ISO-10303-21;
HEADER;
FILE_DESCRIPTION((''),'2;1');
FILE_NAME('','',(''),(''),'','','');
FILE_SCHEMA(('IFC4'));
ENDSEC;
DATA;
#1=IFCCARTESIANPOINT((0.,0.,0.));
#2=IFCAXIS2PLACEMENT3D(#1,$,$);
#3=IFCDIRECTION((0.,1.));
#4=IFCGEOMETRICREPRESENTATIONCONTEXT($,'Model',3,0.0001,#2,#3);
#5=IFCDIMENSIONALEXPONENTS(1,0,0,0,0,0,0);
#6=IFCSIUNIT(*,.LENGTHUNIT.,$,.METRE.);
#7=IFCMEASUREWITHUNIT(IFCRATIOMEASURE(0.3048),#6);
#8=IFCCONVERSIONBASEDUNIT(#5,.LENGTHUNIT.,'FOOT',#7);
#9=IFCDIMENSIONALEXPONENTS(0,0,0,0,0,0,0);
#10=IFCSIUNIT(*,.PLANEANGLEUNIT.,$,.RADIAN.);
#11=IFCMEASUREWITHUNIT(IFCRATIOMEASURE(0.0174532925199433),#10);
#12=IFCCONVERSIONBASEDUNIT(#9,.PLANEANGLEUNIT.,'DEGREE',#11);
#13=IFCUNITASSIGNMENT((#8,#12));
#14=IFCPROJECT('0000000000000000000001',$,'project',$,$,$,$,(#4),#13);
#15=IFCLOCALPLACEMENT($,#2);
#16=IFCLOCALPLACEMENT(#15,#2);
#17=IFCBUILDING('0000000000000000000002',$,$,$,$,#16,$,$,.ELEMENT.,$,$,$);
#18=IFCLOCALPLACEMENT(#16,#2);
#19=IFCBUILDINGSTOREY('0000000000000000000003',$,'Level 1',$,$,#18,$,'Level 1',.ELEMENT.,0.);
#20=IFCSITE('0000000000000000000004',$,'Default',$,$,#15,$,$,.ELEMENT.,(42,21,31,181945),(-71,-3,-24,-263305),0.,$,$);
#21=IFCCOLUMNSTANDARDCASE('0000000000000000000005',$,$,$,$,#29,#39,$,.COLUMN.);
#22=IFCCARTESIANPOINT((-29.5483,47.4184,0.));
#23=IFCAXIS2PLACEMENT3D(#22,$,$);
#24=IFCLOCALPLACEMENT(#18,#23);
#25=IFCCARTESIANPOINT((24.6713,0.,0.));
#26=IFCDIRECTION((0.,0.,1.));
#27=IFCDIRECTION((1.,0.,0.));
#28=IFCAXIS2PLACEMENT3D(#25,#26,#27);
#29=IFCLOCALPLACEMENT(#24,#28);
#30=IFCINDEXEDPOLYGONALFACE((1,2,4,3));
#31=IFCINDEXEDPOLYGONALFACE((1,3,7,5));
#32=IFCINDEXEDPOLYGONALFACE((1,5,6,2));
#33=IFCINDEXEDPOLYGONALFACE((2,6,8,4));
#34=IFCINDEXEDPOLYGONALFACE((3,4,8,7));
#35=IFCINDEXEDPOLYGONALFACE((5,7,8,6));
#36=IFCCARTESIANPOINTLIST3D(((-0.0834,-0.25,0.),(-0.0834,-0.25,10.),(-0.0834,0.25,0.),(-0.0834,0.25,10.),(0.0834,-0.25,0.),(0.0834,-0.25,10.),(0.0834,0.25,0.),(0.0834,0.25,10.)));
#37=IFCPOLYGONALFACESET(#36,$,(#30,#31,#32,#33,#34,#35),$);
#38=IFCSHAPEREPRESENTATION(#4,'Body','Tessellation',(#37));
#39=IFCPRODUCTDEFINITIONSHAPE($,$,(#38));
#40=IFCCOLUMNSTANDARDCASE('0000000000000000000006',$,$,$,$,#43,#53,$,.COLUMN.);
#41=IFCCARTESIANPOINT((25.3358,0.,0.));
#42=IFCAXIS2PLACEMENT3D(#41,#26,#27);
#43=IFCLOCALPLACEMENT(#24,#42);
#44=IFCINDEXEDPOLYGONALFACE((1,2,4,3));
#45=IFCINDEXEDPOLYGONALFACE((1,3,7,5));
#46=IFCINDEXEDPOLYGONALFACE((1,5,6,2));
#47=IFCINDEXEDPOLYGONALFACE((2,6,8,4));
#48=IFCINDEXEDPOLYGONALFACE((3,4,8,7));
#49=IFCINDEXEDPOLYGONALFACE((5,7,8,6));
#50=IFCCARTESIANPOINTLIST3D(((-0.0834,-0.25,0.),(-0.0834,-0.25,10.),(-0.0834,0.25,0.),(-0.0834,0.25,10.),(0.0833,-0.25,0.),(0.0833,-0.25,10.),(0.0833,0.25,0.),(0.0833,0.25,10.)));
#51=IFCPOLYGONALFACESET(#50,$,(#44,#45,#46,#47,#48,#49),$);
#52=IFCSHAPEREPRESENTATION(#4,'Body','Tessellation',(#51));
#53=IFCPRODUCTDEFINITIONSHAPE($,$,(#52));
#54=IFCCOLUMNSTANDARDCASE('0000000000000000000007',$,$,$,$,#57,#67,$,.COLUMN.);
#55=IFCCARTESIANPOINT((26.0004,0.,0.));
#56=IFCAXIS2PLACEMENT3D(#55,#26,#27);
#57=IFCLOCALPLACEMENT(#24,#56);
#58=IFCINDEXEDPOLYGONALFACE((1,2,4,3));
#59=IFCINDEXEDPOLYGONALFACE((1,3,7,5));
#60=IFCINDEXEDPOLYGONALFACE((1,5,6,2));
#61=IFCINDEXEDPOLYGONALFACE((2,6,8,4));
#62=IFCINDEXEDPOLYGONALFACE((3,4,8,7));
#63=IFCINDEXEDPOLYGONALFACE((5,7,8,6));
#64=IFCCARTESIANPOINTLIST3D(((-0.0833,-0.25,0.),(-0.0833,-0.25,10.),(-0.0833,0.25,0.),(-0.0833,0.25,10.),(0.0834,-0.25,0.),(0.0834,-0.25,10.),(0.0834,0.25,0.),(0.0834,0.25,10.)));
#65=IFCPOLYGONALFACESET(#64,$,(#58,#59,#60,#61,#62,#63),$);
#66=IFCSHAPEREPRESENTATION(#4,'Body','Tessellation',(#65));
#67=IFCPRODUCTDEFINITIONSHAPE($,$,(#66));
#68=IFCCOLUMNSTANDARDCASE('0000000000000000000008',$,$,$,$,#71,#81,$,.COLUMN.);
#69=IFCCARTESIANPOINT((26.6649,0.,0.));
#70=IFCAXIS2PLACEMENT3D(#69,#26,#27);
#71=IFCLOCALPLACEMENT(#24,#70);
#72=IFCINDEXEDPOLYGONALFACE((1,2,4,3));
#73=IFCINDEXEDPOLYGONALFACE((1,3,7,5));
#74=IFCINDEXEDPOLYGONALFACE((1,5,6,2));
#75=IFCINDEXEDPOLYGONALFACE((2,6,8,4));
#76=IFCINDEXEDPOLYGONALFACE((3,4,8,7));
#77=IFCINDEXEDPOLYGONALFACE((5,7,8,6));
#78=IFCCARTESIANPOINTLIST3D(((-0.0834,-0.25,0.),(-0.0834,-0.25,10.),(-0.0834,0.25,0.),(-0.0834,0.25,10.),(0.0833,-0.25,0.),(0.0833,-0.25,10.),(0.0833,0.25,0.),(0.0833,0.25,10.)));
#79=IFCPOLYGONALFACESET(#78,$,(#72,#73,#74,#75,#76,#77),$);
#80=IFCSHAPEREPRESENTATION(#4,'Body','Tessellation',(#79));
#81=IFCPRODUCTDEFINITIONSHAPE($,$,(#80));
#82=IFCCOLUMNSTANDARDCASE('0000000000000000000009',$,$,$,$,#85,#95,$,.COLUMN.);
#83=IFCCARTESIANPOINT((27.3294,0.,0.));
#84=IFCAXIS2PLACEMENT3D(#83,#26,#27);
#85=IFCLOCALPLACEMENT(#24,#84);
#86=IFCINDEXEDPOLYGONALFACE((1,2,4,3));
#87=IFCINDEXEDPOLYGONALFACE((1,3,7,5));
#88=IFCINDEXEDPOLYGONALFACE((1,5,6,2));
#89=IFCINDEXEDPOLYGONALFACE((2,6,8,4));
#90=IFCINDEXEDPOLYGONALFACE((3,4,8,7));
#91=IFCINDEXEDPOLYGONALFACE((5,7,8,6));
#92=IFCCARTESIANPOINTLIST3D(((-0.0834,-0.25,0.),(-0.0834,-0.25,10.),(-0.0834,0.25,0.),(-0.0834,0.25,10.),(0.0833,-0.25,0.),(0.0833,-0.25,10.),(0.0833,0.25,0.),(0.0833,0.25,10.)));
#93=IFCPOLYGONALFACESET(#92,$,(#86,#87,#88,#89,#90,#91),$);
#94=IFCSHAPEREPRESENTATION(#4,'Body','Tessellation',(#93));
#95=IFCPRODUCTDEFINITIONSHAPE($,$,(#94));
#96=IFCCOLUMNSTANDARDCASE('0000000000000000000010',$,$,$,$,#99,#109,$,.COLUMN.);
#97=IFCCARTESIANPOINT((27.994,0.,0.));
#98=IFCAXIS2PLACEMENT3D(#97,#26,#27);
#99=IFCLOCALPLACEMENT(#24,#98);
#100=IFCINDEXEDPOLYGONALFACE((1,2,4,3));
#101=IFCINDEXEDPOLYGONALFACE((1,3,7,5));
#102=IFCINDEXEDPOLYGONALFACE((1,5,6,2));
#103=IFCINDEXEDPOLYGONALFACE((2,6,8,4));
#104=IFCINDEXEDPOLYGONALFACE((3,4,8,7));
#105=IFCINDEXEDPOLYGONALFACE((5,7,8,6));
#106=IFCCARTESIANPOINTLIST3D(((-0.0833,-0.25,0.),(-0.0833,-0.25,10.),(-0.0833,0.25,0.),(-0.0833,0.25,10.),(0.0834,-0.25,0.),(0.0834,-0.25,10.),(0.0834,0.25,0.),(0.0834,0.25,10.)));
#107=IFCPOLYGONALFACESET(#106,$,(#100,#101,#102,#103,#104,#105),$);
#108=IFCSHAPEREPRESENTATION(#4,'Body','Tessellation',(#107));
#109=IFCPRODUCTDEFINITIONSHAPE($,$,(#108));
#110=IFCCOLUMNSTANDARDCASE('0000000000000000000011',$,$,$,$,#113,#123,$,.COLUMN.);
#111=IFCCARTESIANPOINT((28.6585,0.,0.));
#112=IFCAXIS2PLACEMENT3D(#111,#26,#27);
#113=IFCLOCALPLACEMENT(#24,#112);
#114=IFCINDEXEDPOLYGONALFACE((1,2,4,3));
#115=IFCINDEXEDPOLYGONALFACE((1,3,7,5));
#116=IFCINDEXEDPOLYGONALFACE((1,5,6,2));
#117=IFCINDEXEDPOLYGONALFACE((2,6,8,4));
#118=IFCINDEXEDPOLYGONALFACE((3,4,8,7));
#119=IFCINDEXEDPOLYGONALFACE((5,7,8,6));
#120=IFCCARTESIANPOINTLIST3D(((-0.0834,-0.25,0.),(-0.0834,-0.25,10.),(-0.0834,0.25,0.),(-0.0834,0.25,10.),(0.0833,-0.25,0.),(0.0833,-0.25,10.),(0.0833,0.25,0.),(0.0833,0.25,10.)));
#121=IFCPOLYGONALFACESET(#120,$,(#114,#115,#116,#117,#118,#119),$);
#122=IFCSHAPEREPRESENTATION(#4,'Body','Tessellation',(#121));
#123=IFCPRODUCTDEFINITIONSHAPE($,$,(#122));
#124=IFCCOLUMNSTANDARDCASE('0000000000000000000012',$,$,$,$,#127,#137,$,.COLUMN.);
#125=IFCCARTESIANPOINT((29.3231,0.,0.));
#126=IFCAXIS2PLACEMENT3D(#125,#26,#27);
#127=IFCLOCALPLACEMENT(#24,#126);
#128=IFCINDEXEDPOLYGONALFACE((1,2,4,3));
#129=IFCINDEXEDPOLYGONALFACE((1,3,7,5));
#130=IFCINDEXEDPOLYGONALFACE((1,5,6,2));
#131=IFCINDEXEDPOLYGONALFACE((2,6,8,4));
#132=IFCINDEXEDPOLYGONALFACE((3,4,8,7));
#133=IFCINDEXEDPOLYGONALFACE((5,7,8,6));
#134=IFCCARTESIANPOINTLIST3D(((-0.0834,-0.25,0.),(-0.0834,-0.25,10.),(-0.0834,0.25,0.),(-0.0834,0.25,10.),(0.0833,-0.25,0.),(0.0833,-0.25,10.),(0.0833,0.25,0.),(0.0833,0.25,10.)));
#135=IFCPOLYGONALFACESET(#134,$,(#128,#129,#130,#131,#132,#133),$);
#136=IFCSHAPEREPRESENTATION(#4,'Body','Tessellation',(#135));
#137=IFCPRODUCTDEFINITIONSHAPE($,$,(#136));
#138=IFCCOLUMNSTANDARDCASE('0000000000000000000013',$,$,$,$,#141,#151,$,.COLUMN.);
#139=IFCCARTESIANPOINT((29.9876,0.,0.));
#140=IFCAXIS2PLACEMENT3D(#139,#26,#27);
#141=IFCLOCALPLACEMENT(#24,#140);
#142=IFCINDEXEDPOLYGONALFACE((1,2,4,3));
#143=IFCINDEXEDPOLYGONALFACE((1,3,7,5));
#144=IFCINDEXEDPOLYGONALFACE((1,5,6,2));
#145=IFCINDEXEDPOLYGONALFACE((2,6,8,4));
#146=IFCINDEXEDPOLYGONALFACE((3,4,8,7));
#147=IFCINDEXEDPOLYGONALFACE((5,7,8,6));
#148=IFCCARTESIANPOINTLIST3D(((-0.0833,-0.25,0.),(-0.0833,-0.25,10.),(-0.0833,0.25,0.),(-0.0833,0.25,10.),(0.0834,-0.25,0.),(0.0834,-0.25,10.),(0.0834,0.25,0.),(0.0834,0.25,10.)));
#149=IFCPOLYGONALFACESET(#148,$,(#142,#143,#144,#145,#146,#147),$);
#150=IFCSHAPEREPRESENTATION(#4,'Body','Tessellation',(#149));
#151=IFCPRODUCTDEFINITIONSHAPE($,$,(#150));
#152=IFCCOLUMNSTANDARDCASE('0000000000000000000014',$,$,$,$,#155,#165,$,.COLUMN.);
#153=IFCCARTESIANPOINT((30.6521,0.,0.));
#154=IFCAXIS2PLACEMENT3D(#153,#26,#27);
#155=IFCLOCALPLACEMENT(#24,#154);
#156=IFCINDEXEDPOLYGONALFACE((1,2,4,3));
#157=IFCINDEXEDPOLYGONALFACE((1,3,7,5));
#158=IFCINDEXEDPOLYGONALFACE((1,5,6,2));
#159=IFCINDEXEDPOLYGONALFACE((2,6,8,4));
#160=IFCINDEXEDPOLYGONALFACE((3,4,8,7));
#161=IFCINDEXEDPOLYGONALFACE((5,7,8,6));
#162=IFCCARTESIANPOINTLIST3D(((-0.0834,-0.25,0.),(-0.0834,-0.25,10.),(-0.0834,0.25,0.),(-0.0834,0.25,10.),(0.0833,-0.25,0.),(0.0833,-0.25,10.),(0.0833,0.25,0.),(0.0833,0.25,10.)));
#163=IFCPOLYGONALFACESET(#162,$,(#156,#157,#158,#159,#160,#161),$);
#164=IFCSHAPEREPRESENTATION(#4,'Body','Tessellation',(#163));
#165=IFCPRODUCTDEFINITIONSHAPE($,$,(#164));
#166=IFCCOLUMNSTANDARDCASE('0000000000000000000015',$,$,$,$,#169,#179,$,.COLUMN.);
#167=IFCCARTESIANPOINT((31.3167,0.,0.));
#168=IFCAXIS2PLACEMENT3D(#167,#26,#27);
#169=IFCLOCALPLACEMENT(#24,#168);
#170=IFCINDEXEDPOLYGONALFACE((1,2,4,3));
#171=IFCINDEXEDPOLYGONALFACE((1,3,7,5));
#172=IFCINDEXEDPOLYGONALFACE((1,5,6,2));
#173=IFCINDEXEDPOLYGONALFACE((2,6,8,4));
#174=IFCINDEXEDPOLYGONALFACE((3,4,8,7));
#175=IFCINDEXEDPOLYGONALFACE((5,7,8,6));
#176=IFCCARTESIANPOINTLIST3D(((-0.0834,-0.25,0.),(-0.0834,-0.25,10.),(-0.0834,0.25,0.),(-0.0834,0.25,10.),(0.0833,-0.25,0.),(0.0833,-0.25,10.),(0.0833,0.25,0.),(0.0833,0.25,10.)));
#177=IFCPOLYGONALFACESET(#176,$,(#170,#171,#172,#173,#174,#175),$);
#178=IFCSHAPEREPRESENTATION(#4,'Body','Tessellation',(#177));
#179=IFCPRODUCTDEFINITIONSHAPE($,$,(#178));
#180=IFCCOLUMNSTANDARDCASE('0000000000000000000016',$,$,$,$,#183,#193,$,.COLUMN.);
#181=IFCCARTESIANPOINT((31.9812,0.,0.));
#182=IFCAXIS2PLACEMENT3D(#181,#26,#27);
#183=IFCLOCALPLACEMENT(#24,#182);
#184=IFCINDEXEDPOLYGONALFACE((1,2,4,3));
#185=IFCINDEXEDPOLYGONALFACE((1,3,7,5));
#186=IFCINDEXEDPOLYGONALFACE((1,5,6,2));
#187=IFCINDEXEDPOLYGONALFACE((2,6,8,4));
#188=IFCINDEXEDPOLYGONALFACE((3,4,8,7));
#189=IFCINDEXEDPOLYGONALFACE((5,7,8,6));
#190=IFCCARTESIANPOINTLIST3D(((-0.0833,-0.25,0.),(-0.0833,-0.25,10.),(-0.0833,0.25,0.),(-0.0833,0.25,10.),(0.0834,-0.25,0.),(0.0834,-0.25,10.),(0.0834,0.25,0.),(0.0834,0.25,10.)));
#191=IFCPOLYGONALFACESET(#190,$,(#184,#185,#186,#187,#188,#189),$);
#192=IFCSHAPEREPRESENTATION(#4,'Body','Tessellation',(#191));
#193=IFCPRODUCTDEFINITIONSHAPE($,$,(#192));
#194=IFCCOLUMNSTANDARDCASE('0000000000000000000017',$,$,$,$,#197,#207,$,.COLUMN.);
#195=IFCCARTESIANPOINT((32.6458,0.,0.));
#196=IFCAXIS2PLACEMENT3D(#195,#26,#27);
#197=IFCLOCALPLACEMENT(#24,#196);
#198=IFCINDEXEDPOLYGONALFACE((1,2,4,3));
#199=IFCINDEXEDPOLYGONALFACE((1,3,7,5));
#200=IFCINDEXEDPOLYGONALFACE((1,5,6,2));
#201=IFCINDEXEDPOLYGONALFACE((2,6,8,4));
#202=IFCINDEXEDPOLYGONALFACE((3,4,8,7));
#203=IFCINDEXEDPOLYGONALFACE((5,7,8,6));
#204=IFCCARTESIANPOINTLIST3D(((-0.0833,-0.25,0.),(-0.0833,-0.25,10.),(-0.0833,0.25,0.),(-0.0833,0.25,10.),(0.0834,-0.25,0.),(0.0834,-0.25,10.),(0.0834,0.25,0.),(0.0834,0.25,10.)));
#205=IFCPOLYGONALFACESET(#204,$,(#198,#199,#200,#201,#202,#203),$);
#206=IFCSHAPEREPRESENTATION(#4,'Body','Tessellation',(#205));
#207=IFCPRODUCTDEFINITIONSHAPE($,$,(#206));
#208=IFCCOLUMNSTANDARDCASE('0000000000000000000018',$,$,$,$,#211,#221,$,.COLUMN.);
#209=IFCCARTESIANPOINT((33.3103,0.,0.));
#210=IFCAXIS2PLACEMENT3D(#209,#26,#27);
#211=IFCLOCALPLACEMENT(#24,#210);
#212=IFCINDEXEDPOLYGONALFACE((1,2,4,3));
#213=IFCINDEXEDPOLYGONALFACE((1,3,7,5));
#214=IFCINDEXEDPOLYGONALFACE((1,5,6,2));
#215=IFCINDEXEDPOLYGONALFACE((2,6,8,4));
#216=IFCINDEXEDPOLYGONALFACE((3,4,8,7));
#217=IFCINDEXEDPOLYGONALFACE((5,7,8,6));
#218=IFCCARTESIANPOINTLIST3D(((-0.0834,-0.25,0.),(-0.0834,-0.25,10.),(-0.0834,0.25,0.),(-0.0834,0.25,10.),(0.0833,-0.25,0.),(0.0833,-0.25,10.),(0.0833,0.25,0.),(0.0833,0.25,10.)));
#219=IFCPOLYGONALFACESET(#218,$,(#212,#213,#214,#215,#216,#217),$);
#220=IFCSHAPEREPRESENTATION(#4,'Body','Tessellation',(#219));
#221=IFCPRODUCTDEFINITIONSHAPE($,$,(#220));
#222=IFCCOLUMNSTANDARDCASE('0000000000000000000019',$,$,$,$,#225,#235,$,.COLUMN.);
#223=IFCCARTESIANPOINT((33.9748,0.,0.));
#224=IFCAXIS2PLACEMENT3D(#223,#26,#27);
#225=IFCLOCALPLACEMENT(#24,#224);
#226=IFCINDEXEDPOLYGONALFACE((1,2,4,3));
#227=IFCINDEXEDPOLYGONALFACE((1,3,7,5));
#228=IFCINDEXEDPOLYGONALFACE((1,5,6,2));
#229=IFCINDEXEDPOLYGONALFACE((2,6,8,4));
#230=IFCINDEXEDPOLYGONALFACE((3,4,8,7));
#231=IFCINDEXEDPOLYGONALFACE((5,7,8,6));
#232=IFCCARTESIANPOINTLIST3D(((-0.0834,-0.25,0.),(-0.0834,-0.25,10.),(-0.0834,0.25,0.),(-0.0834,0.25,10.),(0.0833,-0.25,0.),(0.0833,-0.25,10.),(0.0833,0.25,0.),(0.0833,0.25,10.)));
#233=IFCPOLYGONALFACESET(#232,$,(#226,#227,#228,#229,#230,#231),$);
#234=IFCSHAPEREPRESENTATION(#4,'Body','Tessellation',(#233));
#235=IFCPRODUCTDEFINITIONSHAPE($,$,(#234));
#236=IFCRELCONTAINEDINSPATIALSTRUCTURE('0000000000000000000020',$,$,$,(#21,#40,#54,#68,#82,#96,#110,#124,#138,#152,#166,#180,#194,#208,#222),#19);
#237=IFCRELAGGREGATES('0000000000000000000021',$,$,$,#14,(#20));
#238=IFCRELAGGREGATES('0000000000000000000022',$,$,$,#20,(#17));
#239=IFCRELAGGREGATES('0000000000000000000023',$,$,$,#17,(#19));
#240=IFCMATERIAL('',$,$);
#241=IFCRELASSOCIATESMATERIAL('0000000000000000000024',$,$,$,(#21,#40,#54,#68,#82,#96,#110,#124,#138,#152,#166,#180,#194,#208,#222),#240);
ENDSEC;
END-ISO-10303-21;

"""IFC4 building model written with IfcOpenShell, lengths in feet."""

from ifc_helpers import new_model, entity, si_unit, converted_unit, direction, frame, origin, place, context, project, spatial, rectangle, extrude, material, element, save


model = new_model("IFC4")

# Units and contexts
model_context = context("Model", 3, precision=0.0001, world=origin(), true_north=direction((0.0, 1.0)))
ifc_project = project(units=[converted_unit("LENGTHUNIT", "FOOT", entity("IfcRatioMeasure", 0.3048), si_unit("LENGTHUNIT", "METRE"), dimensions=[1, 0, 0, 0, 0, 0, 0]), converted_unit("PLANEANGLEUNIT", "DEGREE", entity("IfcRatioMeasure", 0.0174532925199433), si_unit("PLANEANGLEUNIT", "RADIAN"), dimensions=[0, 0, 0, 0, 0, 0, 0])], contexts=[model_context])

# Site, building, storey
site_placement = place(None, origin())
site = spatial("IfcSite", under=ifc_project, at=site_placement, Name="Default", CompositionType="ELEMENT", RefLatitude=(42, 21, 31, 181945), RefLongitude=(-71, -3, -24, -263305), RefElevation=0.0)
building_placement = place(site_placement, origin())
building = spatial("IfcBuilding", under=site, at=building_placement, CompositionType="ELEMENT")
storey_placement = place(building_placement, origin())
storey = spatial("IfcBuildingStorey", under=building, at=storey_placement, Name="Level 1", LongName="Level 1", CompositionType="ELEMENT", Elevation=0.0)

# Columns
ifc_material = material(Name="")
placement = place(storey_placement, frame((-29.5483, 47.4184, 0.0)))
for number, where, z_axis, x_axis in (
    (1, (24.6713, 0.0, 0.0), (0.0, 0.0, 1.0), (1.0, 0.0, 0.0)),
    (2, (25.3358, 0.0, 0.0), (0.0, 0.0, 1.0), (1.0, 0.0, 0.0)),
    (3, (26.0004, 0.0, 0.0), (0.0, 0.0, 1.0), (1.0, 0.0, 0.0)),
    (4, (26.6649, 0.0, 0.0), (0.0, 0.0, 1.0), (1.0, 0.0, 0.0)),
    (5, (27.3294, 0.0, 0.0), (0.0, 0.0, 1.0), (1.0, 0.0, 0.0)),
    (6, (27.994, 0.0, 0.0), (0.0, 0.0, 1.0), (1.0, 0.0, 0.0)),
    (7, (28.6585, 0.0, 0.0), (0.0, 0.0, 1.0), (1.0, 0.0, 0.0)),
    (8, (29.3231, 0.0, 0.0), (0.0, 0.0, 1.0), (1.0, 0.0, 0.0)),
    (9, (29.9876, 0.0, 0.0), (0.0, 0.0, 1.0), (1.0, 0.0, 0.0)),
    (10, (30.6521, 0.0, 0.0), (0.0, 0.0, 1.0), (1.0, 0.0, 0.0)),
    (11, (31.3167, 0.0, 0.0), (0.0, 0.0, 1.0), (1.0, 0.0, 0.0)),
    (12, (31.9812, 0.0, 0.0), (0.0, 0.0, 1.0), (1.0, 0.0, 0.0)),
    (13, (32.6458, 0.0, 0.0), (0.0, 0.0, 1.0), (1.0, 0.0, 0.0)),
    (14, (33.3103, 0.0, 0.0), (0.0, 0.0, 1.0), (1.0, 0.0, 0.0)),
    (15, (33.9748, 0.0, 0.0), (0.0, 0.0, 1.0), (1.0, 0.0, 0.0)),
):
    element("IfcColumnStandardCase", number, at=place(placement, frame(where, z_axis=z_axis, x_axis=x_axis)), inside=storey, material=ifc_material, PredefinedType="COLUMN", context=model_context, shape_type="SweptSolid", body=[
        extrude(rectangle(XDim=0.1667, YDim=0.5), origin(), (0.0, 0.0, 1.0), 10.0),
    ])

save(model, "model.ifc")
